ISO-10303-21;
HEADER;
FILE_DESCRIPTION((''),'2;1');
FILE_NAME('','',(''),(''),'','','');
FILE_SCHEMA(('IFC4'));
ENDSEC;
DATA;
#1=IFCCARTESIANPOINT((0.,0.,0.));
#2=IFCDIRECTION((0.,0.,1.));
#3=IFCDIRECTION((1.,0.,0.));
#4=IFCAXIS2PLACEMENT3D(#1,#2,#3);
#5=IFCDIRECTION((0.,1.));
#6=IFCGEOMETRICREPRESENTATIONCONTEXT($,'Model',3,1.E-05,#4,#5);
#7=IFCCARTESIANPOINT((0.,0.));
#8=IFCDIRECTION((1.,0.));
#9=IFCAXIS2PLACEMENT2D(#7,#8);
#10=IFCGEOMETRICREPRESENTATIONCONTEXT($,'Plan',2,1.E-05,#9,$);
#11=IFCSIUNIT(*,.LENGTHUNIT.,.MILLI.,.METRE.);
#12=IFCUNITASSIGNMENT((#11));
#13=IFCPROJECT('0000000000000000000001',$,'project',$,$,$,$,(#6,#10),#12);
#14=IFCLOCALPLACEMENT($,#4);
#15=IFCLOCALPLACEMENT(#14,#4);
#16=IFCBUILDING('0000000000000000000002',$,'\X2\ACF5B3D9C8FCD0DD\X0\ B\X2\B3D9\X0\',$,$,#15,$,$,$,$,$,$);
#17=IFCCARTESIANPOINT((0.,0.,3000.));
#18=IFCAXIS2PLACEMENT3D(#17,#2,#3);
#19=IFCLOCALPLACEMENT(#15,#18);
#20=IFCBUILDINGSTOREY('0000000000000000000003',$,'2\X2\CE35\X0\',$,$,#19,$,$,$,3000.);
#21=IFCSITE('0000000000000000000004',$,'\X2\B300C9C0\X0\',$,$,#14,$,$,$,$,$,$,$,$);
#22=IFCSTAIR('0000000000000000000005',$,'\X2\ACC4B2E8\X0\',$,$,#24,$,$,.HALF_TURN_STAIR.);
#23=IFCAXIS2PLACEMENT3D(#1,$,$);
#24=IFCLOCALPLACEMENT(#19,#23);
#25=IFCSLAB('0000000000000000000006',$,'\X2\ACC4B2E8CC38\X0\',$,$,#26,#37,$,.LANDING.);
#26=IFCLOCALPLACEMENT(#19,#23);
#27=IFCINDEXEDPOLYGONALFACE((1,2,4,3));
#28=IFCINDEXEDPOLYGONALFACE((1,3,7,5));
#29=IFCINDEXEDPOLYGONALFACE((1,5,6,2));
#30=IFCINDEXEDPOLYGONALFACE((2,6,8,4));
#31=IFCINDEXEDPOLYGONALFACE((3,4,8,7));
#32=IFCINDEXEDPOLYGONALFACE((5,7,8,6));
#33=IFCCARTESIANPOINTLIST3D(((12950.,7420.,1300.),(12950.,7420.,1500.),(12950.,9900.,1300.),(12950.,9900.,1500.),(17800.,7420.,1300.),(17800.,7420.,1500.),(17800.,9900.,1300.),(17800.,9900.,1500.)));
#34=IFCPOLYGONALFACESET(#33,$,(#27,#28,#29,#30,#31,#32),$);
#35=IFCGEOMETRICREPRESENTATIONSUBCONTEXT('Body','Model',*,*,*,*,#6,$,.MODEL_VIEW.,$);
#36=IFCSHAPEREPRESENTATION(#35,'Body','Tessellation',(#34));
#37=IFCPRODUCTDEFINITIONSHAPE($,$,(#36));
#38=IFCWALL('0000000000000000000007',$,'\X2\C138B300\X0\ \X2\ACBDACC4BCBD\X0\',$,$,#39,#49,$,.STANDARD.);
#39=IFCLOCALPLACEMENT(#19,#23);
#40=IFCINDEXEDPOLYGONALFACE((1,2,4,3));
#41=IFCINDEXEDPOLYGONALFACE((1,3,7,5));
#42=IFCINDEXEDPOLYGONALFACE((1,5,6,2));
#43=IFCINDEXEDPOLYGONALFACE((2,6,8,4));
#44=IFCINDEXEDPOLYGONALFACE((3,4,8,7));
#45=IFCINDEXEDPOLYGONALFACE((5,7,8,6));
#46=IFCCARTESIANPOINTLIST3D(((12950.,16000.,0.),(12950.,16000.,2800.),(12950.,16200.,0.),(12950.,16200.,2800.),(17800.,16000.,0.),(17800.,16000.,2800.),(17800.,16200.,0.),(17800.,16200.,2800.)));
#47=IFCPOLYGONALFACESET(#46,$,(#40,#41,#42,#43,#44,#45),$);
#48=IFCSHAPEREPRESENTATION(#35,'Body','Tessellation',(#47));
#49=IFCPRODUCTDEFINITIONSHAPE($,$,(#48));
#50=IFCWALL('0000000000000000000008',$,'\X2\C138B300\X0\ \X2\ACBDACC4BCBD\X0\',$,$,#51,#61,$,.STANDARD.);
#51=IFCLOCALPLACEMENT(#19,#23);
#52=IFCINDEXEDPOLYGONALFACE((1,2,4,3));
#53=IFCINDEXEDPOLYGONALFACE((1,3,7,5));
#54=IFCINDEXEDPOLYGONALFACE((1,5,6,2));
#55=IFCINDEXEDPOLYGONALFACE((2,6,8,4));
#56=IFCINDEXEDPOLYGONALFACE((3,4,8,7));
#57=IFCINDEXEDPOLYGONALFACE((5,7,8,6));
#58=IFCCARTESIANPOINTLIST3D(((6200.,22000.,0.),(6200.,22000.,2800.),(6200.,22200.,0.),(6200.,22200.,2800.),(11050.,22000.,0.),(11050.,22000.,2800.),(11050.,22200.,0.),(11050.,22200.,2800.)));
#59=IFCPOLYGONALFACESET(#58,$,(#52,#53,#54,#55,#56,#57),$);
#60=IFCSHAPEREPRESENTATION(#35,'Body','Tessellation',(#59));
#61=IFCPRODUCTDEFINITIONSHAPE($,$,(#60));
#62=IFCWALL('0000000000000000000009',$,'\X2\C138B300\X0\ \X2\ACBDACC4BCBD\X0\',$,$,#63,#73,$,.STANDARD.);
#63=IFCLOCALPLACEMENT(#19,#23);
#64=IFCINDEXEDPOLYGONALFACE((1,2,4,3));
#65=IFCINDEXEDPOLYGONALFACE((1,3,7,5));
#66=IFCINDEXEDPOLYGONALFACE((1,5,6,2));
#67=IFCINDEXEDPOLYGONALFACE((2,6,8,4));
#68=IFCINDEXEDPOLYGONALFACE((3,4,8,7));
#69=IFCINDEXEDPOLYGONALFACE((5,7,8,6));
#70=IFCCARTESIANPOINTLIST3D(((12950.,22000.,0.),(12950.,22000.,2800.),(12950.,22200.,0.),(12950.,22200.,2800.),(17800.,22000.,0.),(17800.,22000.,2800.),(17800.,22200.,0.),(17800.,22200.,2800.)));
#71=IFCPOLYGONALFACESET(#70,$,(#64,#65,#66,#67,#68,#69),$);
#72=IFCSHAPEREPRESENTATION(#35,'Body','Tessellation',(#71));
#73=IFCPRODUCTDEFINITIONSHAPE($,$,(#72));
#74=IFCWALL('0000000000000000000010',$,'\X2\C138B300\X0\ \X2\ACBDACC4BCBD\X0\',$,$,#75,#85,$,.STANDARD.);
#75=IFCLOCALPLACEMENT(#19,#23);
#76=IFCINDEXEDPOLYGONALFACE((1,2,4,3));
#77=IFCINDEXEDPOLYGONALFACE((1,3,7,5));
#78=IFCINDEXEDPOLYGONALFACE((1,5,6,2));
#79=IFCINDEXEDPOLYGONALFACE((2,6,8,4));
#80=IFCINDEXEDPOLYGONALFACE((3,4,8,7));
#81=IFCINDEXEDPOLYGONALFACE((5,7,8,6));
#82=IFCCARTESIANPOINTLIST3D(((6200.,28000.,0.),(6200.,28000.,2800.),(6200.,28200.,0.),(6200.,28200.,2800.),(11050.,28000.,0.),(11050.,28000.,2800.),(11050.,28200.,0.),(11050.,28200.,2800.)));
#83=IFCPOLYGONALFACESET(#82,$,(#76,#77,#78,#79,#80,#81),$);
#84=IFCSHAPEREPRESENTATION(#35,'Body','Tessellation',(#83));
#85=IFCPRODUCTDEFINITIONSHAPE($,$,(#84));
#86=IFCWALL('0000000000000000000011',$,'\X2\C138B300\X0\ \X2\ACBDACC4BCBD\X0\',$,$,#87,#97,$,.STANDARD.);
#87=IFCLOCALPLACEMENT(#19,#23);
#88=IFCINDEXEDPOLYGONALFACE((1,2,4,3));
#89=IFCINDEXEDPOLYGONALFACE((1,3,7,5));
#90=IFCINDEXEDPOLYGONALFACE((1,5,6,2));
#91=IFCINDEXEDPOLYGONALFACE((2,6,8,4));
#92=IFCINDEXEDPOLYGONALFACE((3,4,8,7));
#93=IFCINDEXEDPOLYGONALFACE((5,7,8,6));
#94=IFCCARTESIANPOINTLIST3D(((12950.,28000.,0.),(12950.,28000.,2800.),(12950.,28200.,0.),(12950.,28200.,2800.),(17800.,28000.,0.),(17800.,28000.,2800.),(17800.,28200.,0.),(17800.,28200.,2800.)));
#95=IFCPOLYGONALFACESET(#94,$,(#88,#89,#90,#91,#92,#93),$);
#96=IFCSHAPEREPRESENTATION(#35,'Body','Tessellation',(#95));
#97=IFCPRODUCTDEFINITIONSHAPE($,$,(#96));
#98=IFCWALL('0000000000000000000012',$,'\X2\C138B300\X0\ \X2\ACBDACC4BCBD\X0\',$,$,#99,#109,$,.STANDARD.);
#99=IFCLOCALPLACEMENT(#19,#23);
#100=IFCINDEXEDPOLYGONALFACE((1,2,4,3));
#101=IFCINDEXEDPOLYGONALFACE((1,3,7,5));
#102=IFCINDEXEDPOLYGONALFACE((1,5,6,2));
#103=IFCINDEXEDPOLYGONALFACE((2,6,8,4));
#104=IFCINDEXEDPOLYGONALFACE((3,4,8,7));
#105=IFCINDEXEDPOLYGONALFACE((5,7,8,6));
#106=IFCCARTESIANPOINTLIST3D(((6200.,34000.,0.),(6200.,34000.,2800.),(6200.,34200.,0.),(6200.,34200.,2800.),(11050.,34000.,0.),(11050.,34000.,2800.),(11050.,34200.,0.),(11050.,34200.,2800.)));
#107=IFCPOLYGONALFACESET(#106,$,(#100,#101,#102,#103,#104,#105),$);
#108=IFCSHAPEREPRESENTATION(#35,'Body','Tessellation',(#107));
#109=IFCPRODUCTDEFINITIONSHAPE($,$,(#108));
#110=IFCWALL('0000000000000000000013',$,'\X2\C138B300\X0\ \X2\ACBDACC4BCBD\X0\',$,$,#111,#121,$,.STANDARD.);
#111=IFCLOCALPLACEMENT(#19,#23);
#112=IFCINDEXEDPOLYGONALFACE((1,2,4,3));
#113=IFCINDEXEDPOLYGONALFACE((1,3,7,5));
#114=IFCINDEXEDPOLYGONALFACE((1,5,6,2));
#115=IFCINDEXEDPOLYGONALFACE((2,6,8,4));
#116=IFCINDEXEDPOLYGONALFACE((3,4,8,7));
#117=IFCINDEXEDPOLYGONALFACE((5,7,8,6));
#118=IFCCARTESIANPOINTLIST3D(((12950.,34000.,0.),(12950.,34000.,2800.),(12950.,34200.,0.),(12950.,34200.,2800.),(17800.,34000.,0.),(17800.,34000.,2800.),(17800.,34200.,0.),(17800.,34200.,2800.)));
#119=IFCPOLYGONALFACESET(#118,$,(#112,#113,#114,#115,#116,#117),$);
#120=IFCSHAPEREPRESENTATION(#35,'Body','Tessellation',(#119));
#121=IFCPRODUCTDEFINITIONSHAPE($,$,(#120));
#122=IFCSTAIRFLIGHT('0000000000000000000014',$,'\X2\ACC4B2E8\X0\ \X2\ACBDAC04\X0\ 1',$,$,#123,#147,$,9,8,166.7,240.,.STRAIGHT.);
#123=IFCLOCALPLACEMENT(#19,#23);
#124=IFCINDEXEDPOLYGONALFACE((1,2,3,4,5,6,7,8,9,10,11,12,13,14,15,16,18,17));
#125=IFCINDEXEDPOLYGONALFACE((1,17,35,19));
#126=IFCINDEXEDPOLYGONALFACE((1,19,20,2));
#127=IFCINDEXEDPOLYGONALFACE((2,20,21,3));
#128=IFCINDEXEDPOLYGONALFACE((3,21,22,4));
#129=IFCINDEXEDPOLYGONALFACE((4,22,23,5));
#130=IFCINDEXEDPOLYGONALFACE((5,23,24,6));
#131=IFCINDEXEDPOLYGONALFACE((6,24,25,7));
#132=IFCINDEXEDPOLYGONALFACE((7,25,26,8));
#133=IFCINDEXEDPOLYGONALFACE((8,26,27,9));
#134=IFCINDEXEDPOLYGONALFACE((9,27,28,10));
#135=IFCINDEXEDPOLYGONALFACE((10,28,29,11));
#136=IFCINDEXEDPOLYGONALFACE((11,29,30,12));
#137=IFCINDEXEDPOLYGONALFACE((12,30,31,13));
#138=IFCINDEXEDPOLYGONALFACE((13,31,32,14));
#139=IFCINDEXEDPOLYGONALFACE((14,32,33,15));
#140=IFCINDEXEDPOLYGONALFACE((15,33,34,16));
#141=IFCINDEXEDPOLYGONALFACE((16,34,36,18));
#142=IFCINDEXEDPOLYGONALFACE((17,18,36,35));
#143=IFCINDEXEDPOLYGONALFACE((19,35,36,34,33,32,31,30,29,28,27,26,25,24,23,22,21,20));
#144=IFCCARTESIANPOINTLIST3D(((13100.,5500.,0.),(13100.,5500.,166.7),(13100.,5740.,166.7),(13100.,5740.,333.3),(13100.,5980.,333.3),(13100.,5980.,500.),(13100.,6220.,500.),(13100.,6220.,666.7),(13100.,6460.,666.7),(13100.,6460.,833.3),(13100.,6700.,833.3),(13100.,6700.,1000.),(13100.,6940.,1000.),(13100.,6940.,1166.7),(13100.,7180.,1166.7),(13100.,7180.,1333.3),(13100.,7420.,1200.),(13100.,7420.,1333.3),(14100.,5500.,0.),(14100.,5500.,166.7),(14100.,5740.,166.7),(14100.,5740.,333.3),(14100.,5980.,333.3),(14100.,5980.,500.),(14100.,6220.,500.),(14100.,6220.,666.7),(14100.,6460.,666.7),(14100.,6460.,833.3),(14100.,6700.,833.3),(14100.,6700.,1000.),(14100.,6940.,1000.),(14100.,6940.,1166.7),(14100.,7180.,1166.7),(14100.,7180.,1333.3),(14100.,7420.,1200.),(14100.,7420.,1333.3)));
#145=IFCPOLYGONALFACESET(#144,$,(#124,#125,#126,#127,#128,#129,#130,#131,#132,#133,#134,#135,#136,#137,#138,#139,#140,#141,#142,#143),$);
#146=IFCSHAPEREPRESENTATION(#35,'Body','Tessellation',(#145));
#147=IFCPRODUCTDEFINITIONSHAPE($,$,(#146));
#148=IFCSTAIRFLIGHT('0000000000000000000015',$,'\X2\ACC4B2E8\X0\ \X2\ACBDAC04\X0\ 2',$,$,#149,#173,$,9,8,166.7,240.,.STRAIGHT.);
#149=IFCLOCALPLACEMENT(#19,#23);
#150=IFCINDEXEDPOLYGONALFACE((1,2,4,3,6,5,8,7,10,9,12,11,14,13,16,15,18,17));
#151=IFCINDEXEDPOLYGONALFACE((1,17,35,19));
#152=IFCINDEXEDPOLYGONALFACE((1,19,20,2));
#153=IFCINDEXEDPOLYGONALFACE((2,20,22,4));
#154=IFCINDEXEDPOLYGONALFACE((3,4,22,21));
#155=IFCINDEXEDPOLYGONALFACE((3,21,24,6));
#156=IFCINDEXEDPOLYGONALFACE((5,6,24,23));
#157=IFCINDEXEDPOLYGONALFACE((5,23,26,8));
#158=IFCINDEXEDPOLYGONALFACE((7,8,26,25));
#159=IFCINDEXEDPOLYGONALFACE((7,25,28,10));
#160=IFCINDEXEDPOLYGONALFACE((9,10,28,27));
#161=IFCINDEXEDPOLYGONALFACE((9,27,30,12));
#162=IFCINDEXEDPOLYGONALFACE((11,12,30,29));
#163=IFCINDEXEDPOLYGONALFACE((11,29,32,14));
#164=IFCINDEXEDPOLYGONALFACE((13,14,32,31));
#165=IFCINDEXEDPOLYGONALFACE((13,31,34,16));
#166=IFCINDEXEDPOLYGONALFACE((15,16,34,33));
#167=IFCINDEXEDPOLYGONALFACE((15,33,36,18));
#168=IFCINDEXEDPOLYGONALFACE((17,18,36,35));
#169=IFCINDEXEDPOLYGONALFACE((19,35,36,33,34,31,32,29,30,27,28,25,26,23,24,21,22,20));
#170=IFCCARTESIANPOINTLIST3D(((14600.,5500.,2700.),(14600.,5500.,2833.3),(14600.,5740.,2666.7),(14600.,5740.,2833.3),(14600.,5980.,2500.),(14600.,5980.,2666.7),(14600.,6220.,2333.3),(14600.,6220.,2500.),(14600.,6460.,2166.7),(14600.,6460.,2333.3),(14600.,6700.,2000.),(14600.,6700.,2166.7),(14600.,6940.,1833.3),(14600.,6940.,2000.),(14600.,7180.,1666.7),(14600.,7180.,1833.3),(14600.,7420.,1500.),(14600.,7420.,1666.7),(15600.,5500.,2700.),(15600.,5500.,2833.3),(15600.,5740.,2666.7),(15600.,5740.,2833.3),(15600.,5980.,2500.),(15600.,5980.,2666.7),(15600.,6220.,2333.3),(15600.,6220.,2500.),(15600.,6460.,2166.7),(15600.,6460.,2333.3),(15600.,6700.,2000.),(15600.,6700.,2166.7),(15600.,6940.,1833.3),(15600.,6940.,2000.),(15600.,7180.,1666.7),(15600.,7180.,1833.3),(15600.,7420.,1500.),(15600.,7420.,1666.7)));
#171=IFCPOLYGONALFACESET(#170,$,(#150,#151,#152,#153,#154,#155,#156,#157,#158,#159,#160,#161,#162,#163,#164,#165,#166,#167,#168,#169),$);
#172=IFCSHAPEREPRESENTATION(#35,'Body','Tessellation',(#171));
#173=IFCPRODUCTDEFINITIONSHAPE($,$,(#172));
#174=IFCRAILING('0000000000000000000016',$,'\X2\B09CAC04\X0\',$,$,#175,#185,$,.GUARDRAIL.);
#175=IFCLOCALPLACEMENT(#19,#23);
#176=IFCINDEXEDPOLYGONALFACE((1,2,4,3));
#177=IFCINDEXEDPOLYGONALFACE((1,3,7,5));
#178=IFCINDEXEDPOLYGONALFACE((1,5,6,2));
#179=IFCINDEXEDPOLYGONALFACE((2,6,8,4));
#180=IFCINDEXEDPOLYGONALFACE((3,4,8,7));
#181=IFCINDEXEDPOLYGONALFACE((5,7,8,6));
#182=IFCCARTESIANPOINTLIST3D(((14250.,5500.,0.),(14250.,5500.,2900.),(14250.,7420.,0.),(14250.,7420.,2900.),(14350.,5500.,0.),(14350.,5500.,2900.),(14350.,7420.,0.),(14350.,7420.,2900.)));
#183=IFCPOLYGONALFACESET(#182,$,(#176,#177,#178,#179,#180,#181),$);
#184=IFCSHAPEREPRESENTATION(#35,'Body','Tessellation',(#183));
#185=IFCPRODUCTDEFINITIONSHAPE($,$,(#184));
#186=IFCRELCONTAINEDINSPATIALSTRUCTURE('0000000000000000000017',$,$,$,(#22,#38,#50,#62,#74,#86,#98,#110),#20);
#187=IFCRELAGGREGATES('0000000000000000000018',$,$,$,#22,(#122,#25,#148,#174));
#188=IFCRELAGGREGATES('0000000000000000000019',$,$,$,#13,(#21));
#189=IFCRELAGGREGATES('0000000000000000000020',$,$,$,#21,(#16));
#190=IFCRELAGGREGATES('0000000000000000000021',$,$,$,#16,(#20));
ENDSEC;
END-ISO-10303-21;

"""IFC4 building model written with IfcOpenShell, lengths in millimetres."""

from ifc_helpers import new_model, si_unit, direction, frame, origin_with_axes, origin_2d_with_axis, place, context, subcontext, project, spatial, polyline, outline, extrude, element, aggregate, save


model = new_model("IFC4")

# Units and contexts
model_context = context("Model", 3, precision=1e-05, world=origin_with_axes(), true_north=direction((0.0, 1.0)))
plan_context = context("Plan", 2, precision=1e-05, world=origin_2d_with_axis())
body_context = subcontext(model_context, "Body", "Model", "MODEL_VIEW")
ifc_project = project(units=[si_unit("LENGTHUNIT", "METRE", prefix="MILLI")], contexts=[model_context, plan_context])

# Site, building, storey
site_placement = place(None, origin_with_axes())
site = spatial("IfcSite", under=ifc_project, at=site_placement, Name="대지")
building_placement = place(site_placement, origin_with_axes())
building = spatial("IfcBuilding", under=site, at=building_placement, Name="공동주택 B동")
storey_placement = place(building_placement, frame((0.0, 0.0, 3000.0), z_axis=(0.0, 0.0, 1.0), x_axis=(1.0, 0.0, 0.0)))
storey = spatial("IfcBuildingStorey", under=building, at=storey_placement, Name="2층", Elevation=3000.0)

# Stair, slab
stair_placement = place(storey_placement, origin_with_axes())
stair = element("IfcStair", 1, at=stair_placement, inside=storey, Name="계단", PredefinedType="HALF_TURN_STAIR")
slab_placement = place(stair_placement, origin_with_axes())
slab = element("IfcSlab", 2, at=slab_placement, Name="계단참", PredefinedType="LANDING", context=body_context, shape_type="SweptSolid", body=[
    extrude(outline(polyline([(12950.0, 7420.0), (17800.0, 7420.0), (17800.0, 9900.0), (12950.0, 9900.0), (12950.0, 7420.0)])), frame((0.0, 0.0, 1300.0), z_axis=(0.0, 0.0, 1.0), x_axis=(1.0, 0.0, 0.0)), (0.0, 0.0, 1.0), 200.0),
])

# Walls
wall_1_placement = place(storey_placement, origin_with_axes())
element("IfcWall", 3, at=wall_1_placement, inside=storey, Name="세대 경계벽", PredefinedType="STANDARD", context=body_context, shape_type="SweptSolid", body=[
    extrude(outline(polyline([(12950.0, 16200.0), (17800.0, 16200.0), (17800.0, 16000.0), (12950.0, 16000.0), (12950.0, 16200.0)])), origin_with_axes(), (0.0, 0.0, 1.0), 2800.0),
])
wall_2_placement = place(storey_placement, origin_with_axes())
element("IfcWall", 4, at=wall_2_placement, inside=storey, Name="세대 경계벽", PredefinedType="STANDARD", context=body_context, shape_type="SweptSolid", body=[
    extrude(outline(polyline([(6200.0, 22200.0), (11050.0, 22200.0), (11050.0, 22000.0), (6200.0, 22000.0), (6200.0, 22200.0)])), origin_with_axes(), (0.0, 0.0, 1.0), 2800.0),
])
wall_3_placement = place(storey_placement, origin_with_axes())
element("IfcWall", 5, at=wall_3_placement, inside=storey, Name="세대 경계벽", PredefinedType="STANDARD", context=body_context, shape_type="SweptSolid", body=[
    extrude(outline(polyline([(12950.0, 22200.0), (17800.0, 22200.0), (17800.0, 22000.0), (12950.0, 22000.0), (12950.0, 22200.0)])), origin_with_axes(), (0.0, 0.0, 1.0), 2800.0),
])
wall_4_placement = place(storey_placement, origin_with_axes())
element("IfcWall", 6, at=wall_4_placement, inside=storey, Name="세대 경계벽", PredefinedType="STANDARD", context=body_context, shape_type="SweptSolid", body=[
    extrude(outline(polyline([(6200.0, 28200.0), (11050.0, 28200.0), (11050.0, 28000.0), (6200.0, 28000.0), (6200.0, 28200.0)])), origin_with_axes(), (0.0, 0.0, 1.0), 2800.0),
])
wall_5_placement = place(storey_placement, origin_with_axes())
element("IfcWall", 7, at=wall_5_placement, inside=storey, Name="세대 경계벽", PredefinedType="STANDARD", context=body_context, shape_type="SweptSolid", body=[
    extrude(outline(polyline([(12950.0, 28200.0), (17800.0, 28200.0), (17800.0, 28000.0), (12950.0, 28000.0), (12950.0, 28200.0)])), origin_with_axes(), (0.0, 0.0, 1.0), 2800.0),
])
wall_6_placement = place(storey_placement, origin_with_axes())
element("IfcWall", 8, at=wall_6_placement, inside=storey, Name="세대 경계벽", PredefinedType="STANDARD", context=body_context, shape_type="SweptSolid", body=[
    extrude(outline(polyline([(6200.0, 34200.0), (11050.0, 34200.0), (11050.0, 34000.0), (6200.0, 34000.0), (6200.0, 34200.0)])), origin_with_axes(), (0.0, 0.0, 1.0), 2800.0),
])
wall_7_placement = place(storey_placement, origin_with_axes())
element("IfcWall", 9, at=wall_7_placement, inside=storey, Name="세대 경계벽", PredefinedType="STANDARD", context=body_context, shape_type="SweptSolid", body=[
    extrude(outline(polyline([(12950.0, 34200.0), (17800.0, 34200.0), (17800.0, 34000.0), (12950.0, 34000.0), (12950.0, 34200.0)])), origin_with_axes(), (0.0, 0.0, 1.0), 2800.0),
])

# Stair flights
stair_flight_1_placement = place(stair_placement, origin_with_axes())
stair_flight_1 = element("IfcStairFlight", 10, at=stair_flight_1_placement, Name="계단 경간 1", NumberOfRisers=9, NumberOfTreads=8, PredefinedType="STRAIGHT", RiserHeight=166.7, TreadLength=240.0, context=body_context, shape_type="SweptSolid", body=[
    extrude(outline(polyline([(0.0, 0.0), (0.0, 166.7), (240.0, 166.7), (240.0, 333.3), (480.0, 333.3), (480.0, 500.0), (720.0, 500.0), (720.0, 666.7), (960.0, 666.7), (960.0, 833.3), (1200.0, 833.3), (1200.0, 1000.0), (1440.0, 1000.0), (1440.0, 1166.7), (1680.0, 1166.7), (1680.0, 1333.3), (1920.0, 1333.3), (1920.0, 1500.0), (1920.0, 1200.0), (0.0, 0.0)])), frame((13100.0, 5500.0, 0.0), z_axis=(1.0, 0.0, 0.0), x_axis=(0.0, 1.0, 0.0)), (0.0, 0.0, 1.0), 1000.0),
])
stair_flight_2_placement = place(stair_placement, origin_with_axes())
stair_flight_2 = element("IfcStairFlight", 11, at=stair_flight_2_placement, Name="계단 경간 2", NumberOfRisers=9, NumberOfTreads=8, PredefinedType="STRAIGHT", RiserHeight=166.7, TreadLength=240.0, context=body_context, shape_type="SweptSolid", body=[
    extrude(outline(polyline([(0.0, 0.0), (0.0, 166.7), (240.0, 166.7), (240.0, 333.3), (480.0, 333.3), (480.0, 500.0), (720.0, 500.0), (720.0, 666.7), (960.0, 666.7), (960.0, 833.3), (1200.0, 833.3), (1200.0, 1000.0), (1440.0, 1000.0), (1440.0, 1166.7), (1680.0, 1166.7), (1680.0, 1333.3), (1920.0, 1333.3), (1920.0, 1500.0), (1920.0, 1200.0), (0.0, 0.0)])), frame((15600.0, 7420.0, 1500.0), z_axis=(-1.0, 0.0, 0.0), x_axis=(0.0, -1.0, 0.0)), (0.0, 0.0, 1.0), 1000.0),
])

# Railing
railing_placement = place(stair_placement, origin_with_axes())
railing = element("IfcRailing", 12, at=railing_placement, Name="난간", PredefinedType="GUARDRAIL", context=body_context, shape_type="SweptSolid", body=[
    extrude(outline(polyline([(14250.0, 5500.0), (14350.0, 5500.0), (14350.0, 7420.0), (14250.0, 7420.0), (14250.0, 5500.0)])), origin_with_axes(), (0.0, 0.0, 1.0), 2900.0),
])
aggregate(stair, [stair_flight_1, slab, stair_flight_2, railing])

save(model, "model.ifc")
